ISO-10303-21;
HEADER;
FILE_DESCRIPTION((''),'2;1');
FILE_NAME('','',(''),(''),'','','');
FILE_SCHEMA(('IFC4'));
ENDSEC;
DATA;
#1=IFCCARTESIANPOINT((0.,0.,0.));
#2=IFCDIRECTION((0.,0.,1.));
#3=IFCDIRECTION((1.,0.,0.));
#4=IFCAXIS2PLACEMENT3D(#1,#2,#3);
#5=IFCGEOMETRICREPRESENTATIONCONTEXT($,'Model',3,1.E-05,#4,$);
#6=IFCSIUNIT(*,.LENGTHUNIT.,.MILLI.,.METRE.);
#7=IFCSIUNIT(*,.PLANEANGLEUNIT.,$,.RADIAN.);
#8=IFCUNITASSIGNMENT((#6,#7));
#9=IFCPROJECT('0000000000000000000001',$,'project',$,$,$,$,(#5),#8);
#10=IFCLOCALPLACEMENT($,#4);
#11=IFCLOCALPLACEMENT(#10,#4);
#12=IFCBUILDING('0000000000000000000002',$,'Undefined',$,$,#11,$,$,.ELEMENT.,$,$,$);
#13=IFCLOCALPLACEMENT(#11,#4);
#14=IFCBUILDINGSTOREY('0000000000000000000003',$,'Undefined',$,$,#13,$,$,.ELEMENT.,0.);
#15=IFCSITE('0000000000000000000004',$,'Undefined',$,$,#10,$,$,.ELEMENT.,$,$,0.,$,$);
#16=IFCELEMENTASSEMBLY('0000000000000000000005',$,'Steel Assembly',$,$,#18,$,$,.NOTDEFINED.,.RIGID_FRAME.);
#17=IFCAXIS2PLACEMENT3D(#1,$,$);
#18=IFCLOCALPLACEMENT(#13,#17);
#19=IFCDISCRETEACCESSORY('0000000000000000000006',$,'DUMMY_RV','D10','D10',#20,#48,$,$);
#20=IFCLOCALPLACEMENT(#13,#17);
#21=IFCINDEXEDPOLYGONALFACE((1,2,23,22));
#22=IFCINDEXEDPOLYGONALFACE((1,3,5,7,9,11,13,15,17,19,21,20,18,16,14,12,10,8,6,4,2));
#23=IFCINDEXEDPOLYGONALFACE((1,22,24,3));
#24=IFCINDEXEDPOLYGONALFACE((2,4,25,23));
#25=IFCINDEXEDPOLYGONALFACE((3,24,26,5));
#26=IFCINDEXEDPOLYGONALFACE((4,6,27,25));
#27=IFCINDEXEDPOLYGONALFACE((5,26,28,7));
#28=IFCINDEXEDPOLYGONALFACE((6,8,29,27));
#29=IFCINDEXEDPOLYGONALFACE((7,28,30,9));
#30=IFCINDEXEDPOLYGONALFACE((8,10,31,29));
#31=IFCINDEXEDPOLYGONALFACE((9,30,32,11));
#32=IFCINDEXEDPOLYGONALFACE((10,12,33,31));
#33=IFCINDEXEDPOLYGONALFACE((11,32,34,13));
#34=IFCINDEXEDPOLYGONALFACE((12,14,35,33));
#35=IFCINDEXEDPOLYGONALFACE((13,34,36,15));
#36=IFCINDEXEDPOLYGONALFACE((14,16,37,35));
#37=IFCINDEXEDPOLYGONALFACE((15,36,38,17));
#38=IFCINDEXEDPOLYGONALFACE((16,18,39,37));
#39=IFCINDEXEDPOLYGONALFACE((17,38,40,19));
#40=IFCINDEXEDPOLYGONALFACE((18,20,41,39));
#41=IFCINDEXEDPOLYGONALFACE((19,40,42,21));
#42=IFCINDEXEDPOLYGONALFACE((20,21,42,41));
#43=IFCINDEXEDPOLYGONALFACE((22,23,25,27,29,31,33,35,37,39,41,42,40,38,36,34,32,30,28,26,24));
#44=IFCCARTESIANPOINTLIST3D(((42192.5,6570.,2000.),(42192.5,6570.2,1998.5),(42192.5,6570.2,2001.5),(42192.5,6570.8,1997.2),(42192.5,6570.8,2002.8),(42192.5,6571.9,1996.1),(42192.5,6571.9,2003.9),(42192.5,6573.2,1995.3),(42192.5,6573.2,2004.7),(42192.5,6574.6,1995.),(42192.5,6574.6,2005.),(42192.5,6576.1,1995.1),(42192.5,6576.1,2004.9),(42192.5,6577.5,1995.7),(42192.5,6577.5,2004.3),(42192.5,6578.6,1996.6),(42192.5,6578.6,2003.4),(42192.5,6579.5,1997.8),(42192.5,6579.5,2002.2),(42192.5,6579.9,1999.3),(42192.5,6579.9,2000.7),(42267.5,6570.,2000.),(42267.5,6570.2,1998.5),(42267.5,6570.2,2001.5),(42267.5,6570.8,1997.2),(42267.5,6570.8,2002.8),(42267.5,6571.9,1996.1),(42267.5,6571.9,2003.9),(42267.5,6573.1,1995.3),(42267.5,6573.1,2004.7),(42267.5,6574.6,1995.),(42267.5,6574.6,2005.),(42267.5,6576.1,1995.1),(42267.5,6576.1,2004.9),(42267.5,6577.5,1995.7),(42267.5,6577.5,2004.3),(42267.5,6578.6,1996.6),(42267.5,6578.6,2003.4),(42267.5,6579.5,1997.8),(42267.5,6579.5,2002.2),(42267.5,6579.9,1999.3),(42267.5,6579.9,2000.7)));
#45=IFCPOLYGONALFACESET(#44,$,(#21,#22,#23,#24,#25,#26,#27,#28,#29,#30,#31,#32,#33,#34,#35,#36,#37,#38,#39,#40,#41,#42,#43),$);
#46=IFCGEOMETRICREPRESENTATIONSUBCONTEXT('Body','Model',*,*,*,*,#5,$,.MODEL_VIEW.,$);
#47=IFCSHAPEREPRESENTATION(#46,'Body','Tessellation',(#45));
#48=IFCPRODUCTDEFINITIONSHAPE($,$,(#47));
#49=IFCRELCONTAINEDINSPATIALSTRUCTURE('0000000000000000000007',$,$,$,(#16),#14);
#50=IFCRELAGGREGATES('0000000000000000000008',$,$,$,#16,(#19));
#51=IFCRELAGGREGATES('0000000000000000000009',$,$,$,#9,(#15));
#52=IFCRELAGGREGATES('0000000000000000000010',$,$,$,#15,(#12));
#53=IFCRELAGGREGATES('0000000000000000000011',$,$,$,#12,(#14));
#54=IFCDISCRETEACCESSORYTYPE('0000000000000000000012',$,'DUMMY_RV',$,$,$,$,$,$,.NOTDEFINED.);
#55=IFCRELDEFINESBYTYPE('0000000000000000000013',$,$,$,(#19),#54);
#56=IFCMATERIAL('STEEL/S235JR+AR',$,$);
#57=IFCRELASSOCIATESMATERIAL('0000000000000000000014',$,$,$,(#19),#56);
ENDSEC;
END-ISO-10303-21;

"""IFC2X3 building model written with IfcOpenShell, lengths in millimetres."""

from ifc_helpers import new_model, si_unit, frame, origin_with_axes, origin_2d_with_axis, place, context, subcontext, project, spatial, circle, extrude, material, type_object, element, aggregate, save


model = new_model("IFC2X3")

# Units and contexts
model_context = context("Model", 3, precision=1e-05, world=origin_with_axes())
body_context = subcontext(model_context, "Body", "Model", "MODEL_VIEW")
ifc_project = project(units=[si_unit("LENGTHUNIT", "METRE", prefix="MILLI"), si_unit("PLANEANGLEUNIT", "RADIAN")], contexts=[model_context])

# Site, building, storey
site_placement = place(None, origin_with_axes())
site = spatial("IfcSite", under=ifc_project, at=site_placement, Name="Undefined", CompositionType="ELEMENT", RefElevation=0.0)
building_placement = place(site_placement, origin_with_axes())
building = spatial("IfcBuilding", under=site, at=building_placement, Name="Undefined", CompositionType="ELEMENT")
storey_placement = place(building_placement, origin_with_axes())
storey = spatial("IfcBuildingStorey", under=building, at=storey_placement, Name="Undefined", CompositionType="ELEMENT", Elevation=0.0)

# Element assembly
ifc_material_1 = material(Name="STEEL/S235JR+AR")
assembly_1_placement = place(storey_placement, origin_with_axes())
assembly_1 = element("IfcElementAssembly", 1, at=assembly_1_placement, inside=storey, Name="Steel Assembly", AssemblyPlace="NOTDEFINED", PredefinedType="RIGID_FRAME")

# Discrete accessory
discrete_accessory_type = type_object("IfcDiscreteAccessoryType", Name="DUMMY_RV")
discrete_accessory_1_placement = place(assembly_1_placement, frame((42192.5, 6575.0, 2000.0), z_axis=(0.0, 0.0, 1.0), x_axis=(1.0, -0.00003, 0.0)))
discrete_accessory_1 = element("IfcDiscreteAccessory", 2, at=discrete_accessory_1_placement, type_object=discrete_accessory_type, material=ifc_material_1, Name="DUMMY_RV", Description="D10", ObjectType="D10", context=body_context, shape_type="SweptSolid", body=[
    extrude(circle(Radius=5.0, at=origin_2d_with_axis()), frame((75.0, 0.0, 0.0), z_axis=(-1.0, 0.0, 0.0), x_axis=(0.0, -1.0, 0.0)), (0.0, 0.0, 1.0), 75.0),
])
aggregate(assembly_1, [discrete_accessory_1])

save(model, "model.ifc")
